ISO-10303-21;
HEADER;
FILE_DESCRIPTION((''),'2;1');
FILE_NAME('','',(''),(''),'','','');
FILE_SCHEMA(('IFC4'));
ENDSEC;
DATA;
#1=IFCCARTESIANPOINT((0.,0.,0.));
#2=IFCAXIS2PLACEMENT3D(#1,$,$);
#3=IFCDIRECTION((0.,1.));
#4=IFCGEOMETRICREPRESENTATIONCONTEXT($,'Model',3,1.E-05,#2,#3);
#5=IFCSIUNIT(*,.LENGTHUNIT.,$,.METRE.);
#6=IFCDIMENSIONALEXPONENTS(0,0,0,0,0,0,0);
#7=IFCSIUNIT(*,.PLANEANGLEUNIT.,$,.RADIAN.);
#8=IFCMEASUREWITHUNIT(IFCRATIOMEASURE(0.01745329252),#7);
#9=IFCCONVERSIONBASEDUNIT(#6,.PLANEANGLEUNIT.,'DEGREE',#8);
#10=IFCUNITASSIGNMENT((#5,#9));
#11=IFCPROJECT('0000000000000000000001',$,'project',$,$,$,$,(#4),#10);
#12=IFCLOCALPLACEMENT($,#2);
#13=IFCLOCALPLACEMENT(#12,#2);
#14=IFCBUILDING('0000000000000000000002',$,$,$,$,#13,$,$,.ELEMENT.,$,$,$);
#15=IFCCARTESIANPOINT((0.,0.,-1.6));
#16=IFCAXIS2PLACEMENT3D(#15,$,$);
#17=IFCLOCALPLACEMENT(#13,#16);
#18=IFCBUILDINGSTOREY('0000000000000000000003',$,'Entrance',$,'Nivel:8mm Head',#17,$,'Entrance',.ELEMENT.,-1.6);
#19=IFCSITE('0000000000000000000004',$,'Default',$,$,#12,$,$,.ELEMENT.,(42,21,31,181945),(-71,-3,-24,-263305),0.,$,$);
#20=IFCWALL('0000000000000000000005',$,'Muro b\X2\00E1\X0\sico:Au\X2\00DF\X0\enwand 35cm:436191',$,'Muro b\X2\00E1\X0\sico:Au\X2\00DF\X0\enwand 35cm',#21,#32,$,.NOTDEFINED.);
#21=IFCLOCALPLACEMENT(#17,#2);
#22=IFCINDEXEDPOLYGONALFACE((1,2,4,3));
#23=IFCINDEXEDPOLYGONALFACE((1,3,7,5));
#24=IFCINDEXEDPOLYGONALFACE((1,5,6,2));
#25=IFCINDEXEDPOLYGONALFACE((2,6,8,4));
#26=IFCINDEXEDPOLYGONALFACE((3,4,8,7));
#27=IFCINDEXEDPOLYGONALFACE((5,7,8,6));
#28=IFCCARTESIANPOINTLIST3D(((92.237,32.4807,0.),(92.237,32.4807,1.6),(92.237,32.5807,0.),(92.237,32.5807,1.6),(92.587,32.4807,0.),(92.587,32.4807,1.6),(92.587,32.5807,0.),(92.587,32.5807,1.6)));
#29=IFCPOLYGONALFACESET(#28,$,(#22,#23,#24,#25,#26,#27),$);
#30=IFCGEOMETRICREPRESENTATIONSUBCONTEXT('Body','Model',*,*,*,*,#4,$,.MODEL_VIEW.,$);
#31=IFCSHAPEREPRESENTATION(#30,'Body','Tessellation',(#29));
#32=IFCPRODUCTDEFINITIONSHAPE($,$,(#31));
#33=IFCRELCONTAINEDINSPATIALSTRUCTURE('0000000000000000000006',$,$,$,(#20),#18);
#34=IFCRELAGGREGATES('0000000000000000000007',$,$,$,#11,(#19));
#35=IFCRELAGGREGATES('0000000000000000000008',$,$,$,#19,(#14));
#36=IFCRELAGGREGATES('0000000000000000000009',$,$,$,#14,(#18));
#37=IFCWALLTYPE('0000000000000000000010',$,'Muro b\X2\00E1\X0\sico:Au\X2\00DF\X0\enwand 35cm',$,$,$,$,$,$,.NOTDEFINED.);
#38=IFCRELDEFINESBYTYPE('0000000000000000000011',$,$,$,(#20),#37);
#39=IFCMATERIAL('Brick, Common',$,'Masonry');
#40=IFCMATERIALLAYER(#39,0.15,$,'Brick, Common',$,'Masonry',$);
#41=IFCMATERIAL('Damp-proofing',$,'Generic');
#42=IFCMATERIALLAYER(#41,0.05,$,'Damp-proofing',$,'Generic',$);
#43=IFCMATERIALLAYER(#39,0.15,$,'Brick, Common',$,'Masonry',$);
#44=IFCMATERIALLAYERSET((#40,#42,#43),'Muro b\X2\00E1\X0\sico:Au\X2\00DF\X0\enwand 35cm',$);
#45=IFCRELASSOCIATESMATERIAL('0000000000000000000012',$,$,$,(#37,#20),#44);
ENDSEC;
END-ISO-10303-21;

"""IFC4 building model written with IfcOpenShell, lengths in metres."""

from ifc_helpers import new_model, entity, si_unit, converted_unit, direction, frame, frame_2d, origin, place, context, subcontext, project, spatial, rectangle, extrude, material, layer, layer_set, layer_usage, type_object, element, save


model = new_model("IFC4")

# Units and contexts
model_context = context("Model", 3, precision=1e-05, world=origin(), true_north=direction((0.0, 1.0)))
body_context = subcontext(model_context, "Body", "Model", "MODEL_VIEW")
ifc_project = project(units=[si_unit("LENGTHUNIT", "METRE"), converted_unit("PLANEANGLEUNIT", "DEGREE", entity("IfcRatioMeasure", 0.01745329252), si_unit("PLANEANGLEUNIT", "RADIAN"), dimensions=[0, 0, 0, 0, 0, 0, 0])], contexts=[model_context])

# Site, building, storey
site_placement = place(None, origin())
site = spatial("IfcSite", under=ifc_project, at=site_placement, Name="Default", CompositionType="ELEMENT", RefLatitude=(42, 21, 31, 181945), RefLongitude=(-71, -3, -24, -263305), RefElevation=0.0)
building_placement = place(site_placement, origin())
building = spatial("IfcBuilding", under=site, at=building_placement, CompositionType="ELEMENT")
storey_placement = place(building_placement, frame((0.0, 0.0, -1.6)))
storey = spatial("IfcBuildingStorey", under=building, at=storey_placement, Name="Entrance", ObjectType="Nivel:8mm Head", LongName="Entrance", CompositionType="ELEMENT", Elevation=-1.6)

# Shared definitions
ifc_material_1 = material(Name="Brick, Common", Category="Masonry")
ifc_layer_1 = layer(ifc_material_1, 0.15, Name="Brick, Common", Category="Masonry")
ifc_material_2 = material(Name="Damp-proofing", Category="Generic")
ifc_layer_2 = layer(ifc_material_2, 0.05, Name="Damp-proofing", Category="Generic")
ifc_layer_3 = layer(ifc_material_1, 0.15, Name="Brick, Common", Category="Masonry")
ifc_layer_set_1 = layer_set([ifc_layer_1, ifc_layer_2, ifc_layer_3], Name="Muro básico:Außenwand 35cm")
wall_type = type_object("IfcWallType", Name="Muro básico:Außenwand 35cm", PredefinedType="NOTDEFINED", material=ifc_layer_set_1)

# Wall
ifc_layer_usage_1 = layer_usage(ifc_layer_set_1, "AXIS2", "NEGATIVE", 0.175)
wall_1_placement = place(storey_placement, frame((92.412, 32.4807, 0.0), z_axis=(0.0, 0.0, 1.0), x_axis=(0.0, 1.0, 0.0)))
element("IfcWall", 1, at=wall_1_placement, inside=storey, type_object=wall_type, material=ifc_layer_usage_1, Name="Muro básico:Außenwand 35cm:436191", ObjectType="Muro básico:Außenwand 35cm", PredefinedType="NOTDEFINED", context=body_context, shape_type="SweptSolid", body=[
    extrude(rectangle(XDim=0.1, YDim=0.35, at=frame_2d((0.05, 0.0), x_axis=(-1.0, 0.0))), origin(), (0.0, 0.0, 1.0), 1.6),
])

save(model, "model.ifc")
